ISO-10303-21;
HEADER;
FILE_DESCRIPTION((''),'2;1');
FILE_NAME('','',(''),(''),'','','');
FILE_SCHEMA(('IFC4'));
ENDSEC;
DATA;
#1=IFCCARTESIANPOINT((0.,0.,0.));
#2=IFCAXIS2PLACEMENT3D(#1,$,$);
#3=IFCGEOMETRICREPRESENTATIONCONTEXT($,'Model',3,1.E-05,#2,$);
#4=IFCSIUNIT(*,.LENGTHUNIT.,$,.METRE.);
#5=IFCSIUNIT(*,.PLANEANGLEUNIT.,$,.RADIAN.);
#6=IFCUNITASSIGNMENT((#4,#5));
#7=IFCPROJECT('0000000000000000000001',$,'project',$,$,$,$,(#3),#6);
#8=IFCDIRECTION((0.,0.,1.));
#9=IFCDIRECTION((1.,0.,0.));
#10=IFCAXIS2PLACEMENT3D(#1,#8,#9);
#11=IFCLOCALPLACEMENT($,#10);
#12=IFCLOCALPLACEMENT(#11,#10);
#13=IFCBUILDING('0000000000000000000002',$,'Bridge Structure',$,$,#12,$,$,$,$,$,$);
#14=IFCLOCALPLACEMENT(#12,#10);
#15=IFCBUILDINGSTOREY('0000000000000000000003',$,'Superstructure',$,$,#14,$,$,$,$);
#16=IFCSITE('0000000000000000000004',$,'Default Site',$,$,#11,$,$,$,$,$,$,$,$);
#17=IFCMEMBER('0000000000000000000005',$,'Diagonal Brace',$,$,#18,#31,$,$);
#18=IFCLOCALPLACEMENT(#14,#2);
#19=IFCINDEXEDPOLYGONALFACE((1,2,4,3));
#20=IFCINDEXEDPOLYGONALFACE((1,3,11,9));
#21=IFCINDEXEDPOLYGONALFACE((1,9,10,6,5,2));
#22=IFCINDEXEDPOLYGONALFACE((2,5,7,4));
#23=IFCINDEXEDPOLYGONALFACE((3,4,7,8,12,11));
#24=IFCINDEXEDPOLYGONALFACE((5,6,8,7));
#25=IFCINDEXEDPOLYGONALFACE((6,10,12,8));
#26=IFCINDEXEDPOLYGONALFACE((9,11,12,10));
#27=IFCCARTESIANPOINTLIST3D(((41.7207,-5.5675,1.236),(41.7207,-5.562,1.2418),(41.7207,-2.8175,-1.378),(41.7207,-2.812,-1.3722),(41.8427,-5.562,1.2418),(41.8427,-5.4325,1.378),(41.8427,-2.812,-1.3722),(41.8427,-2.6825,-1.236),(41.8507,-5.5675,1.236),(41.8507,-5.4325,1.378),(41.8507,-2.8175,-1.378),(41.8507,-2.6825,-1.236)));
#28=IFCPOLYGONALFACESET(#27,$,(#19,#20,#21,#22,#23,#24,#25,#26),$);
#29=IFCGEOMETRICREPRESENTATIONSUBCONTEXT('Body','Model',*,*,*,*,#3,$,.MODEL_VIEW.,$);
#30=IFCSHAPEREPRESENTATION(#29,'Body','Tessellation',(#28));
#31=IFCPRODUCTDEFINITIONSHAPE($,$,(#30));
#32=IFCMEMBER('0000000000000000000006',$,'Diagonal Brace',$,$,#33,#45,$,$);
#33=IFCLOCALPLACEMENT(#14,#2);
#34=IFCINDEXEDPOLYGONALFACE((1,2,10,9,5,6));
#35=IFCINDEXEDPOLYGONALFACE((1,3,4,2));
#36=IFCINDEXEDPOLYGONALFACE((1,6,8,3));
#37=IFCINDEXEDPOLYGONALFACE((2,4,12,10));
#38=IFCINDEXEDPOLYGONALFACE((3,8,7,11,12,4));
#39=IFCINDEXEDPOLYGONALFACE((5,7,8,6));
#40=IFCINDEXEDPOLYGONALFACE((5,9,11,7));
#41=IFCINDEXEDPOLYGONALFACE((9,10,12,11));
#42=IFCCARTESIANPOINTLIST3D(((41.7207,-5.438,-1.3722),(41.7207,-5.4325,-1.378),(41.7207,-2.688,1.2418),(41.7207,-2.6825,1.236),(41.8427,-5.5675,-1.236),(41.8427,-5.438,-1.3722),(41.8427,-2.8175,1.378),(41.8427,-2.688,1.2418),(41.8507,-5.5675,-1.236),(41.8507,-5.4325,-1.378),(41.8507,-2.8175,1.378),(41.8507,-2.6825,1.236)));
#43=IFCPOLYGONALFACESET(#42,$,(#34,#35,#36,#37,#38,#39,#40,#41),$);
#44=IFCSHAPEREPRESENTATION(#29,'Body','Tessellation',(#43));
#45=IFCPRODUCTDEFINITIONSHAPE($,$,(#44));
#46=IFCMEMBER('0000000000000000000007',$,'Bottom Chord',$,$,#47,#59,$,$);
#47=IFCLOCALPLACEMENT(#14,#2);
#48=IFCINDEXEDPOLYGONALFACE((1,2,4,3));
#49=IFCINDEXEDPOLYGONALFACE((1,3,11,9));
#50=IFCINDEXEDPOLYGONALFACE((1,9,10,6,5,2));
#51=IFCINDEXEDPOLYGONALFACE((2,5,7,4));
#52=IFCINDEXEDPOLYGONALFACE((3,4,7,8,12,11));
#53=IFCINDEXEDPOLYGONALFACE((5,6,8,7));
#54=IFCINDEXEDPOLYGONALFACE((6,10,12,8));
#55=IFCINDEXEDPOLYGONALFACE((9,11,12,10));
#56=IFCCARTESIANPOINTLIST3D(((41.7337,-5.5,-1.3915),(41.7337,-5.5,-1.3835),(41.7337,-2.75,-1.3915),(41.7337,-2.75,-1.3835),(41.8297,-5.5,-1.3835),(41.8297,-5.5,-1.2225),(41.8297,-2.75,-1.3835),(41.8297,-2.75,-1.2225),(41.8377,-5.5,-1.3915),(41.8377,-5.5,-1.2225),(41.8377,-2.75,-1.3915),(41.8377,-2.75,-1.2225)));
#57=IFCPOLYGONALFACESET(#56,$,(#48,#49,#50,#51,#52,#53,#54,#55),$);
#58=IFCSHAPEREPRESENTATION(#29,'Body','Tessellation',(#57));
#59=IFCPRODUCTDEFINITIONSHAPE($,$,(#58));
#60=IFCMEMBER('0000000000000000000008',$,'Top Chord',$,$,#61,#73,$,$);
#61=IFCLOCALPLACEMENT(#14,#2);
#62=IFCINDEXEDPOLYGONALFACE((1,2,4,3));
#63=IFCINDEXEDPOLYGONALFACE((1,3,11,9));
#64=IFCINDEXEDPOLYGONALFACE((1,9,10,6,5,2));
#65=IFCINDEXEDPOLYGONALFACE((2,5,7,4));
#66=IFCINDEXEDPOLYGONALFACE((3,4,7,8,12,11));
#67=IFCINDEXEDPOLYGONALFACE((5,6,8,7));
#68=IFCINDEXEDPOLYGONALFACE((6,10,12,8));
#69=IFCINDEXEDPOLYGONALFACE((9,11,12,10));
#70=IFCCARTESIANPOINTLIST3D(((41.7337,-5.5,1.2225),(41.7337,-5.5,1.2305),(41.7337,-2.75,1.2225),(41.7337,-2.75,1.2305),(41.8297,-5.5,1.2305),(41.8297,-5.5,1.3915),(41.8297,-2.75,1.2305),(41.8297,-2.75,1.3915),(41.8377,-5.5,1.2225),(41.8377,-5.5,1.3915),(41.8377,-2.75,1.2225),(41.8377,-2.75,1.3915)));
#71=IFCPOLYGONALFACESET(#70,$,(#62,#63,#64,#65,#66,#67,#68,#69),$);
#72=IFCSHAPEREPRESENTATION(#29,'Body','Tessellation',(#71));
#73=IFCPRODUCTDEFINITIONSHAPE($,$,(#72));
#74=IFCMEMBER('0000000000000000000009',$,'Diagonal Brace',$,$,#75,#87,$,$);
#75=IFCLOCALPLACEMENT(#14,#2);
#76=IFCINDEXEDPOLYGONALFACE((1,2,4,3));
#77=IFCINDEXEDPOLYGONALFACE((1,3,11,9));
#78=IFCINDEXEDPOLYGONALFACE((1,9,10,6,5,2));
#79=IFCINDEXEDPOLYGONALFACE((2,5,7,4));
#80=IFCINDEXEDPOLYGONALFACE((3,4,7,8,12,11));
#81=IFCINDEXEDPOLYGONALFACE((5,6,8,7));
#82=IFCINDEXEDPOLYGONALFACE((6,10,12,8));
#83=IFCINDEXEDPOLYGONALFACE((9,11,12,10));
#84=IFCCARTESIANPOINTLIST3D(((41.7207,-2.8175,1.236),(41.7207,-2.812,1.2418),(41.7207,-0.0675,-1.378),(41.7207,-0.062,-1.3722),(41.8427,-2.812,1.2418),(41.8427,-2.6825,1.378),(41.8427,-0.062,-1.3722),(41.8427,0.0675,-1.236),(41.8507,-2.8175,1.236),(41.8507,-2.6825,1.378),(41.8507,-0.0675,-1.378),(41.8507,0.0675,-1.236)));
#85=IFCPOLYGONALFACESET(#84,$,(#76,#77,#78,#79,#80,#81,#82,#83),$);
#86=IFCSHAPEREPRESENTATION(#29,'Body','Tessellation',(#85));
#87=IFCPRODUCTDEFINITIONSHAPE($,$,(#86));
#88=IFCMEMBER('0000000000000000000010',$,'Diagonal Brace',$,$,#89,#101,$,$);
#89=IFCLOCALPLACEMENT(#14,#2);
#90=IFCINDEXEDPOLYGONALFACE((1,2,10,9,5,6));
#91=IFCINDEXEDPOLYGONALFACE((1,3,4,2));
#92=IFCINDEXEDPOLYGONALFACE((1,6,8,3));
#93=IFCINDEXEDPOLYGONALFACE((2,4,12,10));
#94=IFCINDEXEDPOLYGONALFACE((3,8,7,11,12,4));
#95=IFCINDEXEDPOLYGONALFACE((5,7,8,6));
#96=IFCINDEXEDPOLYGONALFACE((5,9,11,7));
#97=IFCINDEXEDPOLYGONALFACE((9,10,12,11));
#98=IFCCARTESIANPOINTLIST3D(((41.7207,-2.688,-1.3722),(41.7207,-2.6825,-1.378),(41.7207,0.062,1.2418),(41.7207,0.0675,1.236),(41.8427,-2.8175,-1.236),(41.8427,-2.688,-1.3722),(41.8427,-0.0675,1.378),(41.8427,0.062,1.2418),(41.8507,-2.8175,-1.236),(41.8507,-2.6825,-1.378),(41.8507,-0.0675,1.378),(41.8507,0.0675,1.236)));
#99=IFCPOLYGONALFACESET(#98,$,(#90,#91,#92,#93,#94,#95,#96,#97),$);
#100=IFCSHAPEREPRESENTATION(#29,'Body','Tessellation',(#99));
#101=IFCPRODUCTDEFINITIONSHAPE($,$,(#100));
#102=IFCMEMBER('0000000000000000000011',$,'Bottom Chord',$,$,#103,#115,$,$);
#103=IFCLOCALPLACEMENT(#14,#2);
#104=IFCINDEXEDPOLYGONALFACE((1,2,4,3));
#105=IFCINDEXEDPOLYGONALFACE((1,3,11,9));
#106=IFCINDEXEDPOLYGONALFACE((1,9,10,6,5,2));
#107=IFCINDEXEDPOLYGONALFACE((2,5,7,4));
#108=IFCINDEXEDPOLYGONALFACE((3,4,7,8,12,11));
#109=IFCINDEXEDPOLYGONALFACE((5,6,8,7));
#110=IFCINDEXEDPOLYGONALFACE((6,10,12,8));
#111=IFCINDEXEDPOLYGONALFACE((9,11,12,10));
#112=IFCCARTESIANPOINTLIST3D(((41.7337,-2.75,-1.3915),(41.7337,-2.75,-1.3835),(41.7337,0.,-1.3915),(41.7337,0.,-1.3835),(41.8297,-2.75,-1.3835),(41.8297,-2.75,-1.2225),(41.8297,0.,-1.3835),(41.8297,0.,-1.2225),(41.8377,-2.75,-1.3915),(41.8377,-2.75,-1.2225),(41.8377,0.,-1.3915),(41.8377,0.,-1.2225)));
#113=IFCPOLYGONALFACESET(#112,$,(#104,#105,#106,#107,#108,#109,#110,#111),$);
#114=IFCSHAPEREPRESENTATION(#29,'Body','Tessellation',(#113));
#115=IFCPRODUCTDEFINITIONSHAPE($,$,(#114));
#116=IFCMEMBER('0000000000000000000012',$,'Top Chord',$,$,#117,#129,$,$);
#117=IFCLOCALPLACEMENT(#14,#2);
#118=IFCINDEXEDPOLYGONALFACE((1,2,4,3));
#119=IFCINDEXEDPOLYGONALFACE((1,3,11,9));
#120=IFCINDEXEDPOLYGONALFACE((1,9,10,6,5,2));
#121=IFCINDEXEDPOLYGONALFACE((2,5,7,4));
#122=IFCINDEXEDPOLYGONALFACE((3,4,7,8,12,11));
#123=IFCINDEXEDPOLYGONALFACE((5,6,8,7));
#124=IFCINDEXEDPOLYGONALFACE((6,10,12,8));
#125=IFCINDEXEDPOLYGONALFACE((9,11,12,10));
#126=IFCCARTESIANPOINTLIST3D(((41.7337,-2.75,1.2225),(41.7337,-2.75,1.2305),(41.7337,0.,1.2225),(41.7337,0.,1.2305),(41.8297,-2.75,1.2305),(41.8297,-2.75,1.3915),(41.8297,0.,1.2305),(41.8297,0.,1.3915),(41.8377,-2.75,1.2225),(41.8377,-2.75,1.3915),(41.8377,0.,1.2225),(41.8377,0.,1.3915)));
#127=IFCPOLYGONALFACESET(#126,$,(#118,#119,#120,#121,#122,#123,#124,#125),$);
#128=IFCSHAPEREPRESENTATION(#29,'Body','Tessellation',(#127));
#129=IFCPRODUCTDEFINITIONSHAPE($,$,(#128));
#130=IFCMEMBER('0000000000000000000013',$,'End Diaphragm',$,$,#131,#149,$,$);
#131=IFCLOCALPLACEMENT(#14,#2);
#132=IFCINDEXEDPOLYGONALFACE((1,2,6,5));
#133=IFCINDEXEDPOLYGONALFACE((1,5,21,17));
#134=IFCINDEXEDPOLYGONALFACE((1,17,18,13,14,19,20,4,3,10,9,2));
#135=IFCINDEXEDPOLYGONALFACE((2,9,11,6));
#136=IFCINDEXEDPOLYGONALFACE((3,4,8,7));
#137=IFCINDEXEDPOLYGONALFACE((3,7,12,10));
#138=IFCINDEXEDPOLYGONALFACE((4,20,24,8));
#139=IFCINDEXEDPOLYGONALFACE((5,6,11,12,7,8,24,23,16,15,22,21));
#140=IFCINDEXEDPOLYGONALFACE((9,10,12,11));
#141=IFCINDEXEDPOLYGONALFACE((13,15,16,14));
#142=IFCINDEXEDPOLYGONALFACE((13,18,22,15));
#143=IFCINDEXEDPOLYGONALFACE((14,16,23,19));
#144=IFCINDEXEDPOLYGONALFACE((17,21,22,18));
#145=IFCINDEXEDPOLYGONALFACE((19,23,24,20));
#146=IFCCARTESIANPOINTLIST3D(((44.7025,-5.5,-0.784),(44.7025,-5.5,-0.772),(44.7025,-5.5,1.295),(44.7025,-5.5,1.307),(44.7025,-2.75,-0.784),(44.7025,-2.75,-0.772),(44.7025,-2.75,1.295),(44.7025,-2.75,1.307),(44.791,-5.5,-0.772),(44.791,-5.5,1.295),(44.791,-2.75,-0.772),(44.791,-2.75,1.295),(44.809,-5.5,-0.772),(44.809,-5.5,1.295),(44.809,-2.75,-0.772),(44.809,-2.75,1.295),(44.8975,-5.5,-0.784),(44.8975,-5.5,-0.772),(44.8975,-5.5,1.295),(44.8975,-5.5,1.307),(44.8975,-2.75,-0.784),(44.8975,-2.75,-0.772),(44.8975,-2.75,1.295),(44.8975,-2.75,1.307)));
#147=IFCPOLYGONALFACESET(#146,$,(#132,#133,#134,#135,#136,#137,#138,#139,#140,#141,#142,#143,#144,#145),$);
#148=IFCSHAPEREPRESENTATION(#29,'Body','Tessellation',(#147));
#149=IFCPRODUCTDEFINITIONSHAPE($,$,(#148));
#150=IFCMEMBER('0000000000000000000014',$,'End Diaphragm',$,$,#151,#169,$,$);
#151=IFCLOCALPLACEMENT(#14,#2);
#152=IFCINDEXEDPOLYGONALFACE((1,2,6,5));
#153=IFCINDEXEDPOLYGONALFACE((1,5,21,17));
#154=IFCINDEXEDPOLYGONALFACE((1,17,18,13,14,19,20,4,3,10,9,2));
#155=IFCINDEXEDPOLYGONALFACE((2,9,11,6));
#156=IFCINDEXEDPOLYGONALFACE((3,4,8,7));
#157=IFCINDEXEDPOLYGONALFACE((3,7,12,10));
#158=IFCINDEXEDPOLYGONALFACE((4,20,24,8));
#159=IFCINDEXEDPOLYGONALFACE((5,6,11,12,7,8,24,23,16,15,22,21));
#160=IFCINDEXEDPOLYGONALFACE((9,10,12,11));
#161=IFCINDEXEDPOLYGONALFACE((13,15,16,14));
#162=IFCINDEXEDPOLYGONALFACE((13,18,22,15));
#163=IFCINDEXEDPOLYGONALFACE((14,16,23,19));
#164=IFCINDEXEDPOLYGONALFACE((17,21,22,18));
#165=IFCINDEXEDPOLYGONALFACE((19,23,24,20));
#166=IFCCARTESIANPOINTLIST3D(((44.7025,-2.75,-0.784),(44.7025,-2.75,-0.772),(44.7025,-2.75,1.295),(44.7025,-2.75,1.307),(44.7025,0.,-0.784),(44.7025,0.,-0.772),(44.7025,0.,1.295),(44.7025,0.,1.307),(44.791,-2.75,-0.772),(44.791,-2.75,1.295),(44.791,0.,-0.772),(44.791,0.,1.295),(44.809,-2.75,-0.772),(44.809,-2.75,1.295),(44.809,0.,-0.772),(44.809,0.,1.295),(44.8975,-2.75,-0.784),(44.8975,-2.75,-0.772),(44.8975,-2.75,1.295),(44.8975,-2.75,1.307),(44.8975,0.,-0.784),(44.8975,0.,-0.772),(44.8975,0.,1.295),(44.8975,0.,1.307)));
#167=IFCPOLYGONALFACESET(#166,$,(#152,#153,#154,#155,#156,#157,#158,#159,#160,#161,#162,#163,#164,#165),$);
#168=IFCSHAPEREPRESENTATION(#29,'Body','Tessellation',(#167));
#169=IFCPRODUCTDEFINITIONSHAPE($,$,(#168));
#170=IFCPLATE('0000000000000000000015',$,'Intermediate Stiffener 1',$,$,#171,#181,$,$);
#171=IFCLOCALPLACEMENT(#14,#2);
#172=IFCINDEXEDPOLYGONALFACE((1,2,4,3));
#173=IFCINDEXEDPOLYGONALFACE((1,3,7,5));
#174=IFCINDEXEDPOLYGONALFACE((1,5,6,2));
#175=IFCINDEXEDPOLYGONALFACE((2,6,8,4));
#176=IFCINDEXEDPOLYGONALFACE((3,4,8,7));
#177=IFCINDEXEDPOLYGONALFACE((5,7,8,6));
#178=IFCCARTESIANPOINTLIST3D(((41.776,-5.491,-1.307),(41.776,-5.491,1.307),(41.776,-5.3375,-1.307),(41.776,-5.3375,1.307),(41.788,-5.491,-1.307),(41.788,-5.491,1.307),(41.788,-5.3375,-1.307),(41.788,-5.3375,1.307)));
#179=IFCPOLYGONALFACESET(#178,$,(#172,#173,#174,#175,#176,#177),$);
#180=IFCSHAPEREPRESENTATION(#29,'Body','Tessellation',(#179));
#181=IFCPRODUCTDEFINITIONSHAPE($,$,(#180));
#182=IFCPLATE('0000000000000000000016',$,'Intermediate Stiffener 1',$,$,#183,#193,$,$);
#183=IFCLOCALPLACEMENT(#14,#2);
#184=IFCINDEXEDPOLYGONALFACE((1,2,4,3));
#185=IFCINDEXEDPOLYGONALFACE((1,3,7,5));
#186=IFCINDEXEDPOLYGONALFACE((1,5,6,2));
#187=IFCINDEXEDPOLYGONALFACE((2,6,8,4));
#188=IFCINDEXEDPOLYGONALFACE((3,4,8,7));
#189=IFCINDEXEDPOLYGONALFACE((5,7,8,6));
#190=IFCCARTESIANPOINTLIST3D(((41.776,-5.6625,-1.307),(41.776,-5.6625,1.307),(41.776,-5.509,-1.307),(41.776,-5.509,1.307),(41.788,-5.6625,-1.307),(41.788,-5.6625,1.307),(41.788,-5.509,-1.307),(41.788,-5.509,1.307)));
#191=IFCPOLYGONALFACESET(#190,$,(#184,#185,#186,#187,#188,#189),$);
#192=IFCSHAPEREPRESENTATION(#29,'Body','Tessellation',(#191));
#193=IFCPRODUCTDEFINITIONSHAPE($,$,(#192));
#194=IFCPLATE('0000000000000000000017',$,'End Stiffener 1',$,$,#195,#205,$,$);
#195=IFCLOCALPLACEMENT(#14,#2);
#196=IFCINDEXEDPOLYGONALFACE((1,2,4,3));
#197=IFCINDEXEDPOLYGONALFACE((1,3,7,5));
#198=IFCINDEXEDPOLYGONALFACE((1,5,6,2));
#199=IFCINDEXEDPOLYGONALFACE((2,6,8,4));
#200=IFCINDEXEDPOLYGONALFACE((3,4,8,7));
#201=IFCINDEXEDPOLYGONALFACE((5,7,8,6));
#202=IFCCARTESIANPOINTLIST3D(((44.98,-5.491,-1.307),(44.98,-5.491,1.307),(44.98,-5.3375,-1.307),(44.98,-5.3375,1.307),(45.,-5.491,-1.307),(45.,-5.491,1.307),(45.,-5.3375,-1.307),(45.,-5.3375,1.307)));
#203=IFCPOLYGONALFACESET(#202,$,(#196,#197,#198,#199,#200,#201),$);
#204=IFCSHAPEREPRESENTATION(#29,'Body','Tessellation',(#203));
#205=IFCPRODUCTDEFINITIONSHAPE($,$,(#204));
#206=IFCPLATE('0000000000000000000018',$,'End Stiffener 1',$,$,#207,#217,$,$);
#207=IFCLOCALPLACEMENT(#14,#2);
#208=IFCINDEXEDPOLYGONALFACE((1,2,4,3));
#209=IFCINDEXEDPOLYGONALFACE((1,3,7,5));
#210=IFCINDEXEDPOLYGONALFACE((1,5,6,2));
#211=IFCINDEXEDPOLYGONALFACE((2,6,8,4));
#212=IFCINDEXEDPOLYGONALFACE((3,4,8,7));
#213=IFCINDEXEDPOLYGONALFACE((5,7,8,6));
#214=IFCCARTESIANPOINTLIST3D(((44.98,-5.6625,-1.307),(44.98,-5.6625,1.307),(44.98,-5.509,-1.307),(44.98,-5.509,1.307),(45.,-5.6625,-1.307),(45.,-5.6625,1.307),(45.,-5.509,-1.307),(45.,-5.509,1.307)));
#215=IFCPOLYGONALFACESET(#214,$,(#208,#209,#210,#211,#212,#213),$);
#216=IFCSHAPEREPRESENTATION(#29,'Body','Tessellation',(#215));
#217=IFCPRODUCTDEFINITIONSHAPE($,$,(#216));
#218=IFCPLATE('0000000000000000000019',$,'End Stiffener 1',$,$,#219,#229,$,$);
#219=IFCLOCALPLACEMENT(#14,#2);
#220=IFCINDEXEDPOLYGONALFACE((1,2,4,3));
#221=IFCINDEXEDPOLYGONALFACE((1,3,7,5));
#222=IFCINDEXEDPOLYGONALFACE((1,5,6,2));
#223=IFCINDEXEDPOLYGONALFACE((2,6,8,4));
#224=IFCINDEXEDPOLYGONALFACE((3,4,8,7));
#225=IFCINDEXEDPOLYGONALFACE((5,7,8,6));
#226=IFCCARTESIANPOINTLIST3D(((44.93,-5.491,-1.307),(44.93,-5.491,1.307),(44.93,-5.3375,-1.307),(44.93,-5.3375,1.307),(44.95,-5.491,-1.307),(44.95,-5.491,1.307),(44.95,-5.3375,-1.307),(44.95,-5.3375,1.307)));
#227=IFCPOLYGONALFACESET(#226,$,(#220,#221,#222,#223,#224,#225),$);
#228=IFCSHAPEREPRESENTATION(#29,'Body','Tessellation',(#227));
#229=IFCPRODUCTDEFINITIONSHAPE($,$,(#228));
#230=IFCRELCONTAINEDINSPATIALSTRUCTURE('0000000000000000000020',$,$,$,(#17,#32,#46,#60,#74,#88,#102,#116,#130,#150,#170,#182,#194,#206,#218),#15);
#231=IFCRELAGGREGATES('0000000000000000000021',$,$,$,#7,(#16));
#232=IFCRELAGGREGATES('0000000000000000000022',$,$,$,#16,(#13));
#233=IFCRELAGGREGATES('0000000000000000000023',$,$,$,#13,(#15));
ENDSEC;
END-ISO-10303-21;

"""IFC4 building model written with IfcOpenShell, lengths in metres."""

from ifc_helpers import new_model, si_unit, frame, origin, origin_with_axes, origin_2d_with_axis, place, context, subcontext, project, spatial, rectangle, i_section, l_section, extrude, element, save


model = new_model("IFC4")

# Units and contexts
model_context = context("Model", 3, precision=1e-05, world=origin())
body_context = subcontext(model_context, "Body", "Model", "MODEL_VIEW")
ifc_project = project(units=[si_unit("LENGTHUNIT", "METRE"), si_unit("PLANEANGLEUNIT", "RADIAN")], contexts=[model_context])

# Site, building, storey
site_placement = place(None, origin_with_axes())
site = spatial("IfcSite", under=ifc_project, at=site_placement, Name="Default Site")
building_placement = place(site_placement, origin_with_axes())
building = spatial("IfcBuilding", under=site, at=building_placement, Name="Bridge Structure")
storey_placement = place(building_placement, origin_with_axes())
storey = spatial("IfcBuildingStorey", under=building, at=storey_placement, Name="Superstructure")

# Members
for number, where, z_axis, x_axis, name in (
    (1, (41.7857, -5.5, 1.307), (0.0, 0.724802, -0.688957), (-1.0, 0.0, 0.0), "Diagonal Brace"),
    (2, (41.7857, -5.5, -1.307), (0.0, 0.724802, 0.688957), (-1.0, 0.0, 0.0), "Diagonal Brace"),
):
    element("IfcMember", number, at=place(storey_placement, frame(where, z_axis=z_axis, x_axis=x_axis)), inside=storey, Name=name, context=body_context, shape_type="SweptSolid", body=[
        extrude(l_section(Depth=0.196, Width=0.13, Thickness=0.008, at=origin_2d_with_axis()), origin_with_axes(), (0.0, 0.0, 1.0), 3.7941),
    ])
for number, where, z_axis, x_axis, name in (
    (3, (41.7857, -5.5, -1.307), (0.0, 1.0, 0.0), (-1.0, 0.0, 0.0), "Bottom Chord"),
    (4, (41.7857, -5.5, 1.307), (0.0, 1.0, 0.0), (-1.0, 0.0, 0.0), "Top Chord"),
):
    element("IfcMember", number, at=place(storey_placement, frame(where, z_axis=z_axis, x_axis=x_axis)), inside=storey, Name=name, context=body_context, shape_type="SweptSolid", body=[
        extrude(l_section(Depth=0.169, Width=0.104, Thickness=0.008, at=origin_2d_with_axis()), origin_with_axes(), (0.0, 0.0, 1.0), 2.75),
    ])
for number, where, z_axis, x_axis, name in (
    (5, (41.7857, -2.75, 1.307), (0.0, 0.724802, -0.688957), (-1.0, 0.0, 0.0), "Diagonal Brace"),
    (6, (41.7857, -2.75, -1.307), (0.0, 0.724802, 0.688957), (-1.0, 0.0, 0.0), "Diagonal Brace"),
):
    element("IfcMember", number, at=place(storey_placement, frame(where, z_axis=z_axis, x_axis=x_axis)), inside=storey, Name=name, context=body_context, shape_type="SweptSolid", body=[
        extrude(l_section(Depth=0.196, Width=0.13, Thickness=0.008, at=origin_2d_with_axis()), origin_with_axes(), (0.0, 0.0, 1.0), 3.7941),
    ])
for number, where, z_axis, x_axis, name in (
    (7, (41.7857, -2.75, -1.307), (0.0, 1.0, 0.0), (-1.0, 0.0, 0.0), "Bottom Chord"),
    (8, (41.7857, -2.75, 1.307), (0.0, 1.0, 0.0), (-1.0, 0.0, 0.0), "Top Chord"),
):
    element("IfcMember", number, at=place(storey_placement, frame(where, z_axis=z_axis, x_axis=x_axis)), inside=storey, Name=name, context=body_context, shape_type="SweptSolid", body=[
        extrude(l_section(Depth=0.169, Width=0.104, Thickness=0.008, at=origin_2d_with_axis()), origin_with_axes(), (0.0, 0.0, 1.0), 2.75),
    ])
for number, where, z_axis, x_axis, name in (
    (9, (44.8, -5.5, 0.2615), (0.0, 1.0, 0.0), (-1.0, 0.0, 0.0), "End Diaphragm"),
    (10, (44.8, -2.75, 0.2615), (0.0, 1.0, 0.0), (-1.0, 0.0, 0.0), "End Diaphragm"),
):
    element("IfcMember", number, at=place(storey_placement, frame(where, z_axis=z_axis, x_axis=x_axis)), inside=storey, Name=name, context=body_context, shape_type="SweptSolid", body=[
        extrude(i_section(OverallWidth=0.195, OverallDepth=2.091, WebThickness=0.018, FlangeThickness=0.012, at=origin_2d_with_axis()), origin_with_axes(), (0.0, 0.0, 1.0), 2.75),
    ])

# Plates
for number, where, z_axis, x_axis, name in (
    (11, (41.782, -5.4143, -1.307), (0.0, 0.0, 1.0), (1.0, 0.0, 0.0), "Intermediate Stiffener 1"),
    (12, (41.782, -5.5857, -1.307), (0.0, 0.0, 1.0), (1.0, 0.0, 0.0), "Intermediate Stiffener 1"),
):
    element("IfcPlate", number, at=place(storey_placement, frame(where, z_axis=z_axis, x_axis=x_axis)), inside=storey, Name=name, context=body_context, shape_type="SweptSolid", body=[
        extrude(rectangle(XDim=0.012, YDim=0.1535, at=origin_2d_with_axis()), origin_with_axes(), (0.0, 0.0, 1.0), 2.614),
    ])
for number, where, z_axis, x_axis, name in (
    (13, (44.99, -5.4143, -1.307), (0.0, 0.0, 1.0), (1.0, 0.0, 0.0), "End Stiffener 1"),
    (14, (44.99, -5.5857, -1.307), (0.0, 0.0, 1.0), (1.0, 0.0, 0.0), "End Stiffener 1"),
    (15, (44.94, -5.4143, -1.307), (0.0, 0.0, 1.0), (1.0, 0.0, 0.0), "End Stiffener 1"),
):
    element("IfcPlate", number, at=place(storey_placement, frame(where, z_axis=z_axis, x_axis=x_axis)), inside=storey, Name=name, context=body_context, shape_type="SweptSolid", body=[
        extrude(rectangle(XDim=0.02, YDim=0.1535, at=origin_2d_with_axis()), origin_with_axes(), (0.0, 0.0, 1.0), 2.614),
    ])

save(model, "model.ifc")
